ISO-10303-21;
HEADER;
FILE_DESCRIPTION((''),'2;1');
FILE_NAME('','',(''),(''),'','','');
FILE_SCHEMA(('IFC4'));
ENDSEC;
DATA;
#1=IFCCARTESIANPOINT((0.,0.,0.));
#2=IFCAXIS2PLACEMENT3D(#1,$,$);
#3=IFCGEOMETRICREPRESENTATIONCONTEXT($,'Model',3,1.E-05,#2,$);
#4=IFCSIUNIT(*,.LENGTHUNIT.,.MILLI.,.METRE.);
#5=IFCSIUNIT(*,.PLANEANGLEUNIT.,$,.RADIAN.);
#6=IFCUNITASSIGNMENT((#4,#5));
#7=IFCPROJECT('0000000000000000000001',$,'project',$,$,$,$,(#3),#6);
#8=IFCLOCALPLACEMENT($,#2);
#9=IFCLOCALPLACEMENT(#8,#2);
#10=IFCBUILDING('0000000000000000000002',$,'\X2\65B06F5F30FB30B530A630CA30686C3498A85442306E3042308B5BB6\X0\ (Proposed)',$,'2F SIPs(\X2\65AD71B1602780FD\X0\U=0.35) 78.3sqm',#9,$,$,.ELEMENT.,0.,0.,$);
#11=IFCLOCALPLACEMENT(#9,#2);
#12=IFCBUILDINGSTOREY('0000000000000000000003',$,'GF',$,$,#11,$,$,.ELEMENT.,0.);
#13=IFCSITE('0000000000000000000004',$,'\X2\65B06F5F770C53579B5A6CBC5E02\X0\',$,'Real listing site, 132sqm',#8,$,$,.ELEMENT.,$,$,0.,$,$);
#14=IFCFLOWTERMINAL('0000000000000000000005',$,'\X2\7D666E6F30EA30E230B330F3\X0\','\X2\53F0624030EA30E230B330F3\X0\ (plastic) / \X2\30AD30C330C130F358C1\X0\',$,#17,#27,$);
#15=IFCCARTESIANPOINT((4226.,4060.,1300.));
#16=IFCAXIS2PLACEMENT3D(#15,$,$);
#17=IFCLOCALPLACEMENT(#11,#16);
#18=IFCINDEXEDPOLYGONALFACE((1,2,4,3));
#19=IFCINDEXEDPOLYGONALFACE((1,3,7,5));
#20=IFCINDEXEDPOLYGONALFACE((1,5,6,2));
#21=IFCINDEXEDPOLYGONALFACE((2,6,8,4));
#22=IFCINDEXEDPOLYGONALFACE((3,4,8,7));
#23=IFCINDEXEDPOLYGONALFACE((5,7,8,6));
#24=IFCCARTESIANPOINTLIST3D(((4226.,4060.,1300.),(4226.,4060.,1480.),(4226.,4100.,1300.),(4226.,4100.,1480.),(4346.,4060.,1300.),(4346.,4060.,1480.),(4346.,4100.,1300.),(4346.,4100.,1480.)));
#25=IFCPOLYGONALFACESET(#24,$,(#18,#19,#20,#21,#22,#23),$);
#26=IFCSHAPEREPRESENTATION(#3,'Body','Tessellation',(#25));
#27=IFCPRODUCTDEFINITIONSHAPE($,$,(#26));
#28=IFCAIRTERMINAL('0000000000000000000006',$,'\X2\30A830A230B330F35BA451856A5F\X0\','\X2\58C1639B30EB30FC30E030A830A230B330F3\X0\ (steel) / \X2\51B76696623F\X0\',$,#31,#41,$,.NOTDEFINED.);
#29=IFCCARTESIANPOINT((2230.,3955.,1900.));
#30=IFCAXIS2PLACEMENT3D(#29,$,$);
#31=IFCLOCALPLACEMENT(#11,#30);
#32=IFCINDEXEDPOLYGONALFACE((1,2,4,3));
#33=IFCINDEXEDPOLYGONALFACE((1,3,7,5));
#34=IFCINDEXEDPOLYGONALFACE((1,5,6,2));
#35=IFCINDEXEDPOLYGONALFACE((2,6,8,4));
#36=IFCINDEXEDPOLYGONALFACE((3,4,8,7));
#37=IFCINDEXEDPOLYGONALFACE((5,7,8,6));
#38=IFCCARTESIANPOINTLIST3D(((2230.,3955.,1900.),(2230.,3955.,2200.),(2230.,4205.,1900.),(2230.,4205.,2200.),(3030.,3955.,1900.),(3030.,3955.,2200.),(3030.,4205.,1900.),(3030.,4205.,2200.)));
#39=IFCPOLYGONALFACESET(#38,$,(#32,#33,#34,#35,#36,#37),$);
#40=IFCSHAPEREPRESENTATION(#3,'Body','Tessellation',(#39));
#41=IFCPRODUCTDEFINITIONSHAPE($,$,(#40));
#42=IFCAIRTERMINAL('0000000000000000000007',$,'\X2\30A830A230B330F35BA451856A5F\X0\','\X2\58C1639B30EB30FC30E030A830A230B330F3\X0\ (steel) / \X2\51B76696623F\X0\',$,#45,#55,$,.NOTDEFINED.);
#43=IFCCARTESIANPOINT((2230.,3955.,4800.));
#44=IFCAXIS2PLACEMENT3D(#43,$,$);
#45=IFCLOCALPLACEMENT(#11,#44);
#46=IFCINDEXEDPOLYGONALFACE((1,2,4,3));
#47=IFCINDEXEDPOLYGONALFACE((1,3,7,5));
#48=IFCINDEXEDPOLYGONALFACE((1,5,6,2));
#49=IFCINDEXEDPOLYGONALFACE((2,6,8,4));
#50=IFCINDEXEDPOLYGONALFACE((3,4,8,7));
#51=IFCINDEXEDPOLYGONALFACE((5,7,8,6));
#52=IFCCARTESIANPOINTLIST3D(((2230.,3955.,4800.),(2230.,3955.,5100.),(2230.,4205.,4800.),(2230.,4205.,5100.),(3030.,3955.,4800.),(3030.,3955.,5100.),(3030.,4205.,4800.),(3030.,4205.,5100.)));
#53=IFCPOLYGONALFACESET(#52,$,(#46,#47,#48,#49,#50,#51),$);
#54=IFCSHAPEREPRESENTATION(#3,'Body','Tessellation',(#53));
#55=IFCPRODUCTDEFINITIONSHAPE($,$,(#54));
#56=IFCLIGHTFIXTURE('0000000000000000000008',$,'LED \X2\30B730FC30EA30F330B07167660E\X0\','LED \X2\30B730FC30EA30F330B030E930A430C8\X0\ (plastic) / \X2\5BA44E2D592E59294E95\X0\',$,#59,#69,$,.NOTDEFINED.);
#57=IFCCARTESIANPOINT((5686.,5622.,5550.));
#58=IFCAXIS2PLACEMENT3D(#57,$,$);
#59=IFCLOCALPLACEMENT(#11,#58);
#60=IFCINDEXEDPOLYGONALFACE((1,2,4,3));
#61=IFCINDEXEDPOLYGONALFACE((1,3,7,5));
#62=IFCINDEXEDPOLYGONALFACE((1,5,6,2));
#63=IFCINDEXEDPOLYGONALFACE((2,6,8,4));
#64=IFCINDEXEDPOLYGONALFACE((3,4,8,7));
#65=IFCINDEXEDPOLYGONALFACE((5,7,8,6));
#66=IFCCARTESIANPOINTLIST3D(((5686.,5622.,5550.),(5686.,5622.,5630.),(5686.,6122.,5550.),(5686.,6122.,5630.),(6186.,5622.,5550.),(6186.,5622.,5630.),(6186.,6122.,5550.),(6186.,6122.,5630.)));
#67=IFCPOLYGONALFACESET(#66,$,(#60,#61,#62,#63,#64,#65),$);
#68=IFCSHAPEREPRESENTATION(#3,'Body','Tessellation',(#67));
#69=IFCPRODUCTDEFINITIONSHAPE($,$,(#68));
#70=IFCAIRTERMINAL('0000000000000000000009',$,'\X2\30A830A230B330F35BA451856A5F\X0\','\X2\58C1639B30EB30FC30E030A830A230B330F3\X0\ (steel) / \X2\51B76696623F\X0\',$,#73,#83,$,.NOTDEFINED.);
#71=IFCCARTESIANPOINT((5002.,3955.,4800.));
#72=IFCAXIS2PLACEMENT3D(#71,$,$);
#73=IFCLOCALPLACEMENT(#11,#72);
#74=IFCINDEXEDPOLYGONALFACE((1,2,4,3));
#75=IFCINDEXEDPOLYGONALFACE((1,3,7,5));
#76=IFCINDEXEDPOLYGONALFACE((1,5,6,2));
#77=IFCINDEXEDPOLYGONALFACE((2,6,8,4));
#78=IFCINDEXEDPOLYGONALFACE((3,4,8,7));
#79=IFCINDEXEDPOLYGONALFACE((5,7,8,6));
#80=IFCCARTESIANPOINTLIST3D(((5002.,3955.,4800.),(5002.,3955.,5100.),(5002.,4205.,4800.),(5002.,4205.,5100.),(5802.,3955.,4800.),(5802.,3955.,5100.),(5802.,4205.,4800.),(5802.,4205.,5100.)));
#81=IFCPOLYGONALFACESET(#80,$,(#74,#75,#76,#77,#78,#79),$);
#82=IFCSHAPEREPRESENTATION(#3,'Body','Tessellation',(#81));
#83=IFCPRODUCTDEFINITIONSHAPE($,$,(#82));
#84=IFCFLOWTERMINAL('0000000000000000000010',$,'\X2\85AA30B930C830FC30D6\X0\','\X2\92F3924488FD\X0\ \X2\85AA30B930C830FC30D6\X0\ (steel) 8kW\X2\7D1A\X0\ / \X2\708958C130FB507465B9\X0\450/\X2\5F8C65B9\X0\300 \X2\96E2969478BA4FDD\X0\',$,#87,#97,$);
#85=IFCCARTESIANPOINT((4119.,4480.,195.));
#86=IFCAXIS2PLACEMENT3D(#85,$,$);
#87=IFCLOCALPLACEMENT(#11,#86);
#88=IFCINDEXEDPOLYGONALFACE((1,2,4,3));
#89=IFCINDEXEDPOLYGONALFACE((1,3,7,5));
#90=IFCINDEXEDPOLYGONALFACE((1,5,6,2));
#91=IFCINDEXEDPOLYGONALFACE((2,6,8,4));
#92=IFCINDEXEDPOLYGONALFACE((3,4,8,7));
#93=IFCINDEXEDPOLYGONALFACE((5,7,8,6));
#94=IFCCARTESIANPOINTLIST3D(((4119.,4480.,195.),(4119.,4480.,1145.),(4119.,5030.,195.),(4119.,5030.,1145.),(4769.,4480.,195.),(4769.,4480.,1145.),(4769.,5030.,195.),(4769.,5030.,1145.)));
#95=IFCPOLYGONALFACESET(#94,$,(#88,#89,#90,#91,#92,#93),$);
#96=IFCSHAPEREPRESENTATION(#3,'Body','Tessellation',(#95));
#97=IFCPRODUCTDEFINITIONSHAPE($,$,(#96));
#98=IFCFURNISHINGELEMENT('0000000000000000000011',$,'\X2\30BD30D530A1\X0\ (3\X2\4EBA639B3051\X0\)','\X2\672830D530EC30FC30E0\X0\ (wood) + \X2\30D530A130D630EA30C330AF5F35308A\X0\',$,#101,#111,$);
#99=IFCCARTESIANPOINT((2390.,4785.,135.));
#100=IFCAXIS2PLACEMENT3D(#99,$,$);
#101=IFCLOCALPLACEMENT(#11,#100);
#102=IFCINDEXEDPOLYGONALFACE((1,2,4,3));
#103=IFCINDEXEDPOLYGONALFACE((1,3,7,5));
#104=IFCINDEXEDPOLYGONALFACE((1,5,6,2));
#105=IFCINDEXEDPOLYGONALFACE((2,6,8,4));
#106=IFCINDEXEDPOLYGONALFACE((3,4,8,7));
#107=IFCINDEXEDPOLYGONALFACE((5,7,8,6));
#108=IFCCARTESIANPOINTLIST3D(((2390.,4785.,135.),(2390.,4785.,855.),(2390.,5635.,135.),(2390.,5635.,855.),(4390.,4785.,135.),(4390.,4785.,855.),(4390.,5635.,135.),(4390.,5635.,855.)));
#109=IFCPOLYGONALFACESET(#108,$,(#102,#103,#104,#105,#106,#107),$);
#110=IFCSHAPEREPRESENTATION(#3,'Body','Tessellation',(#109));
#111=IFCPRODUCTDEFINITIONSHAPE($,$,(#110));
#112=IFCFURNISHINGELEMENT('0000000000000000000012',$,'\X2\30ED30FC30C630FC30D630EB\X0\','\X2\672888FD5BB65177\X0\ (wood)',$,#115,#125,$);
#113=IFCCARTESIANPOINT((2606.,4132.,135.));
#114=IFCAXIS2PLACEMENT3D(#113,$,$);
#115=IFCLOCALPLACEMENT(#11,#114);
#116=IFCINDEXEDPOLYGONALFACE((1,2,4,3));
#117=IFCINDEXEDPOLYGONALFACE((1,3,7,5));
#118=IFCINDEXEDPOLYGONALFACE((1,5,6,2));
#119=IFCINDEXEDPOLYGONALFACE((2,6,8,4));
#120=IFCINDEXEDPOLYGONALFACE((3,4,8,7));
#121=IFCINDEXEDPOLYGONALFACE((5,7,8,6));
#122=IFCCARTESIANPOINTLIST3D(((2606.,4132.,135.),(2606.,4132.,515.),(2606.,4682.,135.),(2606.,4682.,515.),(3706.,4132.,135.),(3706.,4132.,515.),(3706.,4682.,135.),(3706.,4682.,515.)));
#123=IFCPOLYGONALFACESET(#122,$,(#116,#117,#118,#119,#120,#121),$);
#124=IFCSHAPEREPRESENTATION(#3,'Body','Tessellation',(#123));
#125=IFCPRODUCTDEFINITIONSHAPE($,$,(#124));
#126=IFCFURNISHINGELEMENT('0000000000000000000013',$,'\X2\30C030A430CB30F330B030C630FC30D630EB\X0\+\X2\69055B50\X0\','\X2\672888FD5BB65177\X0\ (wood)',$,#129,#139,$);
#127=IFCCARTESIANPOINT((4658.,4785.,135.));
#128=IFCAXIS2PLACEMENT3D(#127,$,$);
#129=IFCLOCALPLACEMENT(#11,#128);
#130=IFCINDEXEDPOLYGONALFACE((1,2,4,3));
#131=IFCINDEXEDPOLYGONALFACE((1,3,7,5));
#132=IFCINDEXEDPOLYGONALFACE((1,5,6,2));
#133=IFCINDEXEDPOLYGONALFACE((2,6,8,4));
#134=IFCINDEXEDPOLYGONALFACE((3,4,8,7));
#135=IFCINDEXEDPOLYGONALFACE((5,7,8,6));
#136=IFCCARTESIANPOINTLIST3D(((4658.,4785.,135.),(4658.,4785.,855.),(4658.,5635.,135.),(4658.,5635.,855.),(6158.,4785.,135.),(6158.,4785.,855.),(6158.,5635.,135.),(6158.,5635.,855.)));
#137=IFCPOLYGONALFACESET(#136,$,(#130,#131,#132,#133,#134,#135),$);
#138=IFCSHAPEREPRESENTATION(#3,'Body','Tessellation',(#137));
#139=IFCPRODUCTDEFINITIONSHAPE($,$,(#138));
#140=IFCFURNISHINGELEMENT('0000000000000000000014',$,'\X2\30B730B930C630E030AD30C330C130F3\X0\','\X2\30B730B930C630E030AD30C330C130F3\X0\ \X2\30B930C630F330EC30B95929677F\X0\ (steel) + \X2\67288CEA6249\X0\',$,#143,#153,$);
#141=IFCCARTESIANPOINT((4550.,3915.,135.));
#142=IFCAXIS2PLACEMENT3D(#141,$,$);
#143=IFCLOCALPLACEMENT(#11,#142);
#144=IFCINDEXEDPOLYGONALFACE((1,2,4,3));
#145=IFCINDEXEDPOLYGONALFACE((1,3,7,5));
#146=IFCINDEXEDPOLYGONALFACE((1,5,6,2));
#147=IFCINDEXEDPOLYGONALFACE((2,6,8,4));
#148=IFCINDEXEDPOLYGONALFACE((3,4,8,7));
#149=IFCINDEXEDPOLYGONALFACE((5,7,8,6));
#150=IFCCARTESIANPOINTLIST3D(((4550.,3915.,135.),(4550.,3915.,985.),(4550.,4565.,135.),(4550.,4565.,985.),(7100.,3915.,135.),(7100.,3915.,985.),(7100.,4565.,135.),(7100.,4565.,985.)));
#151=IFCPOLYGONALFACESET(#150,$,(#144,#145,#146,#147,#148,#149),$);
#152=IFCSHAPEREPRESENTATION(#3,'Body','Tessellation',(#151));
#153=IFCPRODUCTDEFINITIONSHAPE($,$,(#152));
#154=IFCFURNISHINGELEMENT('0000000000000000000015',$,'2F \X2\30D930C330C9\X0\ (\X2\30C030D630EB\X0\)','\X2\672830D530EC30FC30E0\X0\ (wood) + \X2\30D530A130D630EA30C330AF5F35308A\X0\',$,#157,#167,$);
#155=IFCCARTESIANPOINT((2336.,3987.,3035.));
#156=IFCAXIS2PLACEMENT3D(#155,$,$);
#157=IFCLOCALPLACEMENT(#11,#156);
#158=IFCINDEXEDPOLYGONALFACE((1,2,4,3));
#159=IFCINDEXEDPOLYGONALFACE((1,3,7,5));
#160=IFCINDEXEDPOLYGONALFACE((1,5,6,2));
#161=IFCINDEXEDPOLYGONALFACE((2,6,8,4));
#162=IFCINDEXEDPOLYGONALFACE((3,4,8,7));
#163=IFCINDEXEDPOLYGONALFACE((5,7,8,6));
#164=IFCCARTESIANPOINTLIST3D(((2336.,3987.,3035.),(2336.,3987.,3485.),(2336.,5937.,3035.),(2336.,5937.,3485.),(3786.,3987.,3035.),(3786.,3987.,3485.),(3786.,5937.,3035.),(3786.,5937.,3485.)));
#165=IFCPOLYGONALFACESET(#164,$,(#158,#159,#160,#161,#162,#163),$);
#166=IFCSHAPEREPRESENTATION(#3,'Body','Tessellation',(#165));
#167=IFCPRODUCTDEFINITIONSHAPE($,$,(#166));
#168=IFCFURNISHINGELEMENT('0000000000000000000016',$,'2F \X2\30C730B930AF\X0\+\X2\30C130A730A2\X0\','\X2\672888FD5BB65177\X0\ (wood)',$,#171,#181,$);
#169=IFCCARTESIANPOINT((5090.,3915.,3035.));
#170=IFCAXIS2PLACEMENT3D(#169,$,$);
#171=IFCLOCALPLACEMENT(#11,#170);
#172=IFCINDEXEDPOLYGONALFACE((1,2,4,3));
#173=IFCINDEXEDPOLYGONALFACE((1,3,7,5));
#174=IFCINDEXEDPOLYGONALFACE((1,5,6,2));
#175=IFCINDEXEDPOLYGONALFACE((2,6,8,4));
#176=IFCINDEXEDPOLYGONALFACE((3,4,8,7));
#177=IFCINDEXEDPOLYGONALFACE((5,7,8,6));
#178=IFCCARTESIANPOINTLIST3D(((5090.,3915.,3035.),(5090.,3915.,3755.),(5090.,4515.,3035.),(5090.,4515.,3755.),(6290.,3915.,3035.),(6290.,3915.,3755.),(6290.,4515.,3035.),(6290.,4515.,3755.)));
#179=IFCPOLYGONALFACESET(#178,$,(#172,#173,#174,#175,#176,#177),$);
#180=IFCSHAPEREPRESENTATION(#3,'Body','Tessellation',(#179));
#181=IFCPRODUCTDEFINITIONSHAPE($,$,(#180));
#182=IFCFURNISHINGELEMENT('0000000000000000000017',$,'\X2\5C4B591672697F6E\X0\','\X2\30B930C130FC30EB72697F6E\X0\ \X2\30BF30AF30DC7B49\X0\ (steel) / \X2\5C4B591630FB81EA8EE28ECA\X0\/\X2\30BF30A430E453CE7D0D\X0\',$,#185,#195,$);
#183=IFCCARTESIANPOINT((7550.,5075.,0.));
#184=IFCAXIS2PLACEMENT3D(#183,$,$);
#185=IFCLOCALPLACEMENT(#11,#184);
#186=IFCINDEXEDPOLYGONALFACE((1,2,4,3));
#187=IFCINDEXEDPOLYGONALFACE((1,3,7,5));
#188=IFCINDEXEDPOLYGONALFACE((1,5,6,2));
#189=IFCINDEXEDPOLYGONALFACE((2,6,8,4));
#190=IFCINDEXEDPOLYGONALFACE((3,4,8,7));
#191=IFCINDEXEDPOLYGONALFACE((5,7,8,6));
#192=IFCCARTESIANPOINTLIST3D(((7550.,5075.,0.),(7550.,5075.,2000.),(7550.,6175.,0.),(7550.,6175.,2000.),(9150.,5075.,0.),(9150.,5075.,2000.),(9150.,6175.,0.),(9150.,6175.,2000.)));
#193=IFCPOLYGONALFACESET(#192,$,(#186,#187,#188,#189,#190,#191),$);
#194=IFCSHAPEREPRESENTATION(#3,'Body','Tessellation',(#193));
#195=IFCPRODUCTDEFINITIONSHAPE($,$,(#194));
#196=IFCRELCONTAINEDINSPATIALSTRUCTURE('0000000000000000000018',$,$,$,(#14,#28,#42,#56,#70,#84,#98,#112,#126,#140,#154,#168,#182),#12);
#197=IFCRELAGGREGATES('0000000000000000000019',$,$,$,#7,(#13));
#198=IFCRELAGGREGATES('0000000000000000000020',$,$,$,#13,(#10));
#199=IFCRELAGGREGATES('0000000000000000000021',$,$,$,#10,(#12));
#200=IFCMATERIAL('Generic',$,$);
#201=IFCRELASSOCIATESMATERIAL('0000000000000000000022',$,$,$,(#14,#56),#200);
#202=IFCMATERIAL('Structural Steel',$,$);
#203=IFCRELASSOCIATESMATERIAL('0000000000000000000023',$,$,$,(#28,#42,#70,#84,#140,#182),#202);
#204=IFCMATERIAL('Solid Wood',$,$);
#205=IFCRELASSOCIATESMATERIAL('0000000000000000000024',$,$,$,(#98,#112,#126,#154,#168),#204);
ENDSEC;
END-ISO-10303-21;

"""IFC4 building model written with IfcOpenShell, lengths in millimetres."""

from ifc_helpers import new_model, si_unit, frame, frame_2d, origin, place, context, project, spatial, rectangle, extrude, material, element, save


model = new_model("IFC4")

# Units and contexts
model_context = context("Model", 3, precision=1e-05, world=origin())
ifc_project = project(units=[si_unit("LENGTHUNIT", "METRE", prefix="MILLI"), si_unit("PLANEANGLEUNIT", "RADIAN")], contexts=[model_context])

# Site, building, storey
site_placement = place(None, origin())
site = spatial("IfcSite", under=ifc_project, at=site_placement, Name="新潟県南魚沼市", ObjectType="Real listing site, 132sqm", CompositionType="ELEMENT", RefElevation=0.0)
building_placement = place(site_placement, origin())
building = spatial("IfcBuilding", under=site, at=building_placement, Name="新潟・サウナと水風呂のある家 (Proposed)", ObjectType="2F SIPs(断熱性能U=0.35) 78.3sqm", CompositionType="ELEMENT", ElevationOfRefHeight=0.0, ElevationOfTerrain=0.0)
storey_placement = place(building_placement, origin())
storey = spatial("IfcBuildingStorey", under=building, at=storey_placement, Name="GF", CompositionType="ELEMENT", Elevation=0.0)

# Shared definitions
ifc_material_1 = material(Name="Solid Wood")

# Shared definitions
ifc_material_2 = material(Name="Structural Steel")

# Shared definitions
ifc_material_3 = material(Name="Generic")

# Flow terminal
flow_terminal_1_placement = place(storey_placement, frame((4226.0, 4060.0, 1300.0)))
element("IfcFlowTerminal", 1, at=flow_terminal_1_placement, inside=storey, material=ifc_material_3, Name="給湯リモコン", Description="台所リモコン (plastic) / キッチン壁", context=model_context, shape_type="SweptSolid", body=[
    extrude(rectangle(XDim=120.0, YDim=40.0, at=frame_2d((60.0, 20.0))), frame((4226.0, 4060.0, 1300.0)), (0.0, 0.0, 1.0), 180.0),
])

# Air terminals
air_terminal_1_placement = place(storey_placement, frame((2230.0, 3955.0, 1900.0)))
element("IfcAirTerminal", 2, at=air_terminal_1_placement, inside=storey, material=ifc_material_2, Name="エアコン室内機", Description="壁掛ルームエアコン (steel) / 冷暖房", PredefinedType="NOTDEFINED", context=model_context, shape_type="SweptSolid", body=[
    extrude(rectangle(XDim=800.0, YDim=250.0, at=frame_2d((400.0, 125.0))), frame((2230.0, 3955.0, 1900.0)), (0.0, 0.0, 1.0), 300.0),
])
air_terminal_2_placement = place(storey_placement, frame((2230.0, 3955.0, 4800.0)))
element("IfcAirTerminal", 3, at=air_terminal_2_placement, inside=storey, material=ifc_material_2, Name="エアコン室内機", Description="壁掛ルームエアコン (steel) / 冷暖房", PredefinedType="NOTDEFINED", context=model_context, shape_type="SweptSolid", body=[
    extrude(rectangle(XDim=800.0, YDim=250.0, at=frame_2d((400.0, 125.0))), frame((2230.0, 3955.0, 4800.0)), (0.0, 0.0, 1.0), 300.0),
])

# Light fixture
light_fixture_placement = place(storey_placement, frame((5686.0, 5622.0, 5550.0)))
element("IfcLightFixture", 4, at=light_fixture_placement, inside=storey, material=ifc_material_3, Name="LED シーリング照明", Description="LED シーリングライト (plastic) / 室中央天井", PredefinedType="NOTDEFINED", context=model_context, shape_type="SweptSolid", body=[
    extrude(rectangle(XDim=500.0, YDim=500.0, at=frame_2d((250.0, 250.0))), frame((5686.0, 5622.0, 5550.0)), (0.0, 0.0, 1.0), 80.0),
])

# Air terminal
air_terminal_3_placement = place(storey_placement, frame((5002.0, 3955.0, 4800.0)))
element("IfcAirTerminal", 5, at=air_terminal_3_placement, inside=storey, material=ifc_material_2, Name="エアコン室内機", Description="壁掛ルームエアコン (steel) / 冷暖房", PredefinedType="NOTDEFINED", context=model_context, shape_type="SweptSolid", body=[
    extrude(rectangle(XDim=800.0, YDim=250.0, at=frame_2d((400.0, 125.0))), frame((5002.0, 3955.0, 4800.0)), (0.0, 0.0, 1.0), 300.0),
])

# Flow terminal
flow_terminal_2_placement = place(storey_placement, frame((4119.0, 4480.0, 195.0)))
element("IfcFlowTerminal", 6, at=flow_terminal_2_placement, inside=storey, material=ifc_material_2, Name="薪ストーブ", Description="鋳鉄製 薪ストーブ (steel) 8kW級 / 炉壁・側方450/後方300 離隔確保", context=model_context, shape_type="SweptSolid", body=[
    extrude(rectangle(XDim=650.0, YDim=550.0, at=frame_2d((325.0, 275.0))), frame((4119.0, 4480.0, 195.0)), (0.0, 0.0, 1.0), 950.0),
])

# Furnishing elements
furnishing_1_placement = place(storey_placement, frame((2390.0, 4785.0, 135.0)))
element("IfcFurnishingElement", 7, at=furnishing_1_placement, inside=storey, material=ifc_material_1, Name="ソファ (3人掛け)", Description="木フレーム (wood) + ファブリック張り", context=model_context, shape_type="SweptSolid", body=[
    extrude(rectangle(XDim=2000.0, YDim=850.0, at=frame_2d((1000.0, 425.0))), frame((2390.0, 4785.0, 135.0)), (0.0, 0.0, 1.0), 720.0),
])
furnishing_2_placement = place(storey_placement, frame((2606.0, 4132.0, 135.0)))
element("IfcFurnishingElement", 8, at=furnishing_2_placement, inside=storey, material=ifc_material_1, Name="ローテーブル", Description="木製家具 (wood)", context=model_context, shape_type="SweptSolid", body=[
    extrude(rectangle(XDim=1100.0, YDim=550.0, at=frame_2d((550.0, 275.0))), frame((2606.0, 4132.0, 135.0)), (0.0, 0.0, 1.0), 380.0),
])
furnishing_3_placement = place(storey_placement, frame((4658.0, 4785.0, 135.0)))
element("IfcFurnishingElement", 9, at=furnishing_3_placement, inside=storey, material=ifc_material_1, Name="ダイニングテーブル+椅子", Description="木製家具 (wood)", context=model_context, shape_type="SweptSolid", body=[
    extrude(rectangle(XDim=1500.0, YDim=850.0, at=frame_2d((750.0, 425.0))), frame((4658.0, 4785.0, 135.0)), (0.0, 0.0, 1.0), 720.0),
])
furnishing_4_placement = place(storey_placement, frame((4550.0, 3915.0, 135.0)))
element("IfcFurnishingElement", 10, at=furnishing_4_placement, inside=storey, material=ifc_material_2, Name="システムキッチン", Description="システムキッチン ステンレス天板 (steel) + 木質扉", context=model_context, shape_type="SweptSolid", body=[
    extrude(rectangle(XDim=2550.0, YDim=650.0, at=frame_2d((1275.0, 325.0))), frame((4550.0, 3915.0, 135.0)), (0.0, 0.0, 1.0), 850.0),
])
furnishing_5_placement = place(storey_placement, frame((2336.0, 3987.0, 3035.0)))
element("IfcFurnishingElement", 11, at=furnishing_5_placement, inside=storey, material=ifc_material_1, Name="2F ベッド (ダブル)", Description="木フレーム (wood) + ファブリック張り", context=model_context, shape_type="SweptSolid", body=[
    extrude(rectangle(XDim=1450.0, YDim=1950.0, at=frame_2d((725.0, 975.0))), frame((2336.0, 3987.0, 3035.0)), (0.0, 0.0, 1.0), 450.0),
])
furnishing_6_placement = place(storey_placement, frame((5090.0, 3915.0, 3035.0)))
element("IfcFurnishingElement", 12, at=furnishing_6_placement, inside=storey, material=ifc_material_1, Name="2F デスク+チェア", Description="木製家具 (wood)", context=model_context, shape_type="SweptSolid", body=[
    extrude(rectangle(XDim=1200.0, YDim=600.0, at=frame_2d((600.0, 300.0))), frame((5090.0, 3915.0, 3035.0)), (0.0, 0.0, 1.0), 720.0),
])
furnishing_7_placement = place(storey_placement, frame((7550.0, 5075.0, 0.0)))
element("IfcFurnishingElement", 13, at=furnishing_7_placement, inside=storey, material=ifc_material_2, Name="屋外物置", Description="スチール物置 タクボ等 (steel) / 屋外・自転車/タイヤ収納", context=model_context, shape_type="SweptSolid", body=[
    extrude(rectangle(XDim=1600.0, YDim=1100.0, at=frame_2d((800.0, 550.0))), frame((7550.0, 5075.0, 0.0)), (0.0, 0.0, 1.0), 2000.0),
])

save(model, "model.ifc")
